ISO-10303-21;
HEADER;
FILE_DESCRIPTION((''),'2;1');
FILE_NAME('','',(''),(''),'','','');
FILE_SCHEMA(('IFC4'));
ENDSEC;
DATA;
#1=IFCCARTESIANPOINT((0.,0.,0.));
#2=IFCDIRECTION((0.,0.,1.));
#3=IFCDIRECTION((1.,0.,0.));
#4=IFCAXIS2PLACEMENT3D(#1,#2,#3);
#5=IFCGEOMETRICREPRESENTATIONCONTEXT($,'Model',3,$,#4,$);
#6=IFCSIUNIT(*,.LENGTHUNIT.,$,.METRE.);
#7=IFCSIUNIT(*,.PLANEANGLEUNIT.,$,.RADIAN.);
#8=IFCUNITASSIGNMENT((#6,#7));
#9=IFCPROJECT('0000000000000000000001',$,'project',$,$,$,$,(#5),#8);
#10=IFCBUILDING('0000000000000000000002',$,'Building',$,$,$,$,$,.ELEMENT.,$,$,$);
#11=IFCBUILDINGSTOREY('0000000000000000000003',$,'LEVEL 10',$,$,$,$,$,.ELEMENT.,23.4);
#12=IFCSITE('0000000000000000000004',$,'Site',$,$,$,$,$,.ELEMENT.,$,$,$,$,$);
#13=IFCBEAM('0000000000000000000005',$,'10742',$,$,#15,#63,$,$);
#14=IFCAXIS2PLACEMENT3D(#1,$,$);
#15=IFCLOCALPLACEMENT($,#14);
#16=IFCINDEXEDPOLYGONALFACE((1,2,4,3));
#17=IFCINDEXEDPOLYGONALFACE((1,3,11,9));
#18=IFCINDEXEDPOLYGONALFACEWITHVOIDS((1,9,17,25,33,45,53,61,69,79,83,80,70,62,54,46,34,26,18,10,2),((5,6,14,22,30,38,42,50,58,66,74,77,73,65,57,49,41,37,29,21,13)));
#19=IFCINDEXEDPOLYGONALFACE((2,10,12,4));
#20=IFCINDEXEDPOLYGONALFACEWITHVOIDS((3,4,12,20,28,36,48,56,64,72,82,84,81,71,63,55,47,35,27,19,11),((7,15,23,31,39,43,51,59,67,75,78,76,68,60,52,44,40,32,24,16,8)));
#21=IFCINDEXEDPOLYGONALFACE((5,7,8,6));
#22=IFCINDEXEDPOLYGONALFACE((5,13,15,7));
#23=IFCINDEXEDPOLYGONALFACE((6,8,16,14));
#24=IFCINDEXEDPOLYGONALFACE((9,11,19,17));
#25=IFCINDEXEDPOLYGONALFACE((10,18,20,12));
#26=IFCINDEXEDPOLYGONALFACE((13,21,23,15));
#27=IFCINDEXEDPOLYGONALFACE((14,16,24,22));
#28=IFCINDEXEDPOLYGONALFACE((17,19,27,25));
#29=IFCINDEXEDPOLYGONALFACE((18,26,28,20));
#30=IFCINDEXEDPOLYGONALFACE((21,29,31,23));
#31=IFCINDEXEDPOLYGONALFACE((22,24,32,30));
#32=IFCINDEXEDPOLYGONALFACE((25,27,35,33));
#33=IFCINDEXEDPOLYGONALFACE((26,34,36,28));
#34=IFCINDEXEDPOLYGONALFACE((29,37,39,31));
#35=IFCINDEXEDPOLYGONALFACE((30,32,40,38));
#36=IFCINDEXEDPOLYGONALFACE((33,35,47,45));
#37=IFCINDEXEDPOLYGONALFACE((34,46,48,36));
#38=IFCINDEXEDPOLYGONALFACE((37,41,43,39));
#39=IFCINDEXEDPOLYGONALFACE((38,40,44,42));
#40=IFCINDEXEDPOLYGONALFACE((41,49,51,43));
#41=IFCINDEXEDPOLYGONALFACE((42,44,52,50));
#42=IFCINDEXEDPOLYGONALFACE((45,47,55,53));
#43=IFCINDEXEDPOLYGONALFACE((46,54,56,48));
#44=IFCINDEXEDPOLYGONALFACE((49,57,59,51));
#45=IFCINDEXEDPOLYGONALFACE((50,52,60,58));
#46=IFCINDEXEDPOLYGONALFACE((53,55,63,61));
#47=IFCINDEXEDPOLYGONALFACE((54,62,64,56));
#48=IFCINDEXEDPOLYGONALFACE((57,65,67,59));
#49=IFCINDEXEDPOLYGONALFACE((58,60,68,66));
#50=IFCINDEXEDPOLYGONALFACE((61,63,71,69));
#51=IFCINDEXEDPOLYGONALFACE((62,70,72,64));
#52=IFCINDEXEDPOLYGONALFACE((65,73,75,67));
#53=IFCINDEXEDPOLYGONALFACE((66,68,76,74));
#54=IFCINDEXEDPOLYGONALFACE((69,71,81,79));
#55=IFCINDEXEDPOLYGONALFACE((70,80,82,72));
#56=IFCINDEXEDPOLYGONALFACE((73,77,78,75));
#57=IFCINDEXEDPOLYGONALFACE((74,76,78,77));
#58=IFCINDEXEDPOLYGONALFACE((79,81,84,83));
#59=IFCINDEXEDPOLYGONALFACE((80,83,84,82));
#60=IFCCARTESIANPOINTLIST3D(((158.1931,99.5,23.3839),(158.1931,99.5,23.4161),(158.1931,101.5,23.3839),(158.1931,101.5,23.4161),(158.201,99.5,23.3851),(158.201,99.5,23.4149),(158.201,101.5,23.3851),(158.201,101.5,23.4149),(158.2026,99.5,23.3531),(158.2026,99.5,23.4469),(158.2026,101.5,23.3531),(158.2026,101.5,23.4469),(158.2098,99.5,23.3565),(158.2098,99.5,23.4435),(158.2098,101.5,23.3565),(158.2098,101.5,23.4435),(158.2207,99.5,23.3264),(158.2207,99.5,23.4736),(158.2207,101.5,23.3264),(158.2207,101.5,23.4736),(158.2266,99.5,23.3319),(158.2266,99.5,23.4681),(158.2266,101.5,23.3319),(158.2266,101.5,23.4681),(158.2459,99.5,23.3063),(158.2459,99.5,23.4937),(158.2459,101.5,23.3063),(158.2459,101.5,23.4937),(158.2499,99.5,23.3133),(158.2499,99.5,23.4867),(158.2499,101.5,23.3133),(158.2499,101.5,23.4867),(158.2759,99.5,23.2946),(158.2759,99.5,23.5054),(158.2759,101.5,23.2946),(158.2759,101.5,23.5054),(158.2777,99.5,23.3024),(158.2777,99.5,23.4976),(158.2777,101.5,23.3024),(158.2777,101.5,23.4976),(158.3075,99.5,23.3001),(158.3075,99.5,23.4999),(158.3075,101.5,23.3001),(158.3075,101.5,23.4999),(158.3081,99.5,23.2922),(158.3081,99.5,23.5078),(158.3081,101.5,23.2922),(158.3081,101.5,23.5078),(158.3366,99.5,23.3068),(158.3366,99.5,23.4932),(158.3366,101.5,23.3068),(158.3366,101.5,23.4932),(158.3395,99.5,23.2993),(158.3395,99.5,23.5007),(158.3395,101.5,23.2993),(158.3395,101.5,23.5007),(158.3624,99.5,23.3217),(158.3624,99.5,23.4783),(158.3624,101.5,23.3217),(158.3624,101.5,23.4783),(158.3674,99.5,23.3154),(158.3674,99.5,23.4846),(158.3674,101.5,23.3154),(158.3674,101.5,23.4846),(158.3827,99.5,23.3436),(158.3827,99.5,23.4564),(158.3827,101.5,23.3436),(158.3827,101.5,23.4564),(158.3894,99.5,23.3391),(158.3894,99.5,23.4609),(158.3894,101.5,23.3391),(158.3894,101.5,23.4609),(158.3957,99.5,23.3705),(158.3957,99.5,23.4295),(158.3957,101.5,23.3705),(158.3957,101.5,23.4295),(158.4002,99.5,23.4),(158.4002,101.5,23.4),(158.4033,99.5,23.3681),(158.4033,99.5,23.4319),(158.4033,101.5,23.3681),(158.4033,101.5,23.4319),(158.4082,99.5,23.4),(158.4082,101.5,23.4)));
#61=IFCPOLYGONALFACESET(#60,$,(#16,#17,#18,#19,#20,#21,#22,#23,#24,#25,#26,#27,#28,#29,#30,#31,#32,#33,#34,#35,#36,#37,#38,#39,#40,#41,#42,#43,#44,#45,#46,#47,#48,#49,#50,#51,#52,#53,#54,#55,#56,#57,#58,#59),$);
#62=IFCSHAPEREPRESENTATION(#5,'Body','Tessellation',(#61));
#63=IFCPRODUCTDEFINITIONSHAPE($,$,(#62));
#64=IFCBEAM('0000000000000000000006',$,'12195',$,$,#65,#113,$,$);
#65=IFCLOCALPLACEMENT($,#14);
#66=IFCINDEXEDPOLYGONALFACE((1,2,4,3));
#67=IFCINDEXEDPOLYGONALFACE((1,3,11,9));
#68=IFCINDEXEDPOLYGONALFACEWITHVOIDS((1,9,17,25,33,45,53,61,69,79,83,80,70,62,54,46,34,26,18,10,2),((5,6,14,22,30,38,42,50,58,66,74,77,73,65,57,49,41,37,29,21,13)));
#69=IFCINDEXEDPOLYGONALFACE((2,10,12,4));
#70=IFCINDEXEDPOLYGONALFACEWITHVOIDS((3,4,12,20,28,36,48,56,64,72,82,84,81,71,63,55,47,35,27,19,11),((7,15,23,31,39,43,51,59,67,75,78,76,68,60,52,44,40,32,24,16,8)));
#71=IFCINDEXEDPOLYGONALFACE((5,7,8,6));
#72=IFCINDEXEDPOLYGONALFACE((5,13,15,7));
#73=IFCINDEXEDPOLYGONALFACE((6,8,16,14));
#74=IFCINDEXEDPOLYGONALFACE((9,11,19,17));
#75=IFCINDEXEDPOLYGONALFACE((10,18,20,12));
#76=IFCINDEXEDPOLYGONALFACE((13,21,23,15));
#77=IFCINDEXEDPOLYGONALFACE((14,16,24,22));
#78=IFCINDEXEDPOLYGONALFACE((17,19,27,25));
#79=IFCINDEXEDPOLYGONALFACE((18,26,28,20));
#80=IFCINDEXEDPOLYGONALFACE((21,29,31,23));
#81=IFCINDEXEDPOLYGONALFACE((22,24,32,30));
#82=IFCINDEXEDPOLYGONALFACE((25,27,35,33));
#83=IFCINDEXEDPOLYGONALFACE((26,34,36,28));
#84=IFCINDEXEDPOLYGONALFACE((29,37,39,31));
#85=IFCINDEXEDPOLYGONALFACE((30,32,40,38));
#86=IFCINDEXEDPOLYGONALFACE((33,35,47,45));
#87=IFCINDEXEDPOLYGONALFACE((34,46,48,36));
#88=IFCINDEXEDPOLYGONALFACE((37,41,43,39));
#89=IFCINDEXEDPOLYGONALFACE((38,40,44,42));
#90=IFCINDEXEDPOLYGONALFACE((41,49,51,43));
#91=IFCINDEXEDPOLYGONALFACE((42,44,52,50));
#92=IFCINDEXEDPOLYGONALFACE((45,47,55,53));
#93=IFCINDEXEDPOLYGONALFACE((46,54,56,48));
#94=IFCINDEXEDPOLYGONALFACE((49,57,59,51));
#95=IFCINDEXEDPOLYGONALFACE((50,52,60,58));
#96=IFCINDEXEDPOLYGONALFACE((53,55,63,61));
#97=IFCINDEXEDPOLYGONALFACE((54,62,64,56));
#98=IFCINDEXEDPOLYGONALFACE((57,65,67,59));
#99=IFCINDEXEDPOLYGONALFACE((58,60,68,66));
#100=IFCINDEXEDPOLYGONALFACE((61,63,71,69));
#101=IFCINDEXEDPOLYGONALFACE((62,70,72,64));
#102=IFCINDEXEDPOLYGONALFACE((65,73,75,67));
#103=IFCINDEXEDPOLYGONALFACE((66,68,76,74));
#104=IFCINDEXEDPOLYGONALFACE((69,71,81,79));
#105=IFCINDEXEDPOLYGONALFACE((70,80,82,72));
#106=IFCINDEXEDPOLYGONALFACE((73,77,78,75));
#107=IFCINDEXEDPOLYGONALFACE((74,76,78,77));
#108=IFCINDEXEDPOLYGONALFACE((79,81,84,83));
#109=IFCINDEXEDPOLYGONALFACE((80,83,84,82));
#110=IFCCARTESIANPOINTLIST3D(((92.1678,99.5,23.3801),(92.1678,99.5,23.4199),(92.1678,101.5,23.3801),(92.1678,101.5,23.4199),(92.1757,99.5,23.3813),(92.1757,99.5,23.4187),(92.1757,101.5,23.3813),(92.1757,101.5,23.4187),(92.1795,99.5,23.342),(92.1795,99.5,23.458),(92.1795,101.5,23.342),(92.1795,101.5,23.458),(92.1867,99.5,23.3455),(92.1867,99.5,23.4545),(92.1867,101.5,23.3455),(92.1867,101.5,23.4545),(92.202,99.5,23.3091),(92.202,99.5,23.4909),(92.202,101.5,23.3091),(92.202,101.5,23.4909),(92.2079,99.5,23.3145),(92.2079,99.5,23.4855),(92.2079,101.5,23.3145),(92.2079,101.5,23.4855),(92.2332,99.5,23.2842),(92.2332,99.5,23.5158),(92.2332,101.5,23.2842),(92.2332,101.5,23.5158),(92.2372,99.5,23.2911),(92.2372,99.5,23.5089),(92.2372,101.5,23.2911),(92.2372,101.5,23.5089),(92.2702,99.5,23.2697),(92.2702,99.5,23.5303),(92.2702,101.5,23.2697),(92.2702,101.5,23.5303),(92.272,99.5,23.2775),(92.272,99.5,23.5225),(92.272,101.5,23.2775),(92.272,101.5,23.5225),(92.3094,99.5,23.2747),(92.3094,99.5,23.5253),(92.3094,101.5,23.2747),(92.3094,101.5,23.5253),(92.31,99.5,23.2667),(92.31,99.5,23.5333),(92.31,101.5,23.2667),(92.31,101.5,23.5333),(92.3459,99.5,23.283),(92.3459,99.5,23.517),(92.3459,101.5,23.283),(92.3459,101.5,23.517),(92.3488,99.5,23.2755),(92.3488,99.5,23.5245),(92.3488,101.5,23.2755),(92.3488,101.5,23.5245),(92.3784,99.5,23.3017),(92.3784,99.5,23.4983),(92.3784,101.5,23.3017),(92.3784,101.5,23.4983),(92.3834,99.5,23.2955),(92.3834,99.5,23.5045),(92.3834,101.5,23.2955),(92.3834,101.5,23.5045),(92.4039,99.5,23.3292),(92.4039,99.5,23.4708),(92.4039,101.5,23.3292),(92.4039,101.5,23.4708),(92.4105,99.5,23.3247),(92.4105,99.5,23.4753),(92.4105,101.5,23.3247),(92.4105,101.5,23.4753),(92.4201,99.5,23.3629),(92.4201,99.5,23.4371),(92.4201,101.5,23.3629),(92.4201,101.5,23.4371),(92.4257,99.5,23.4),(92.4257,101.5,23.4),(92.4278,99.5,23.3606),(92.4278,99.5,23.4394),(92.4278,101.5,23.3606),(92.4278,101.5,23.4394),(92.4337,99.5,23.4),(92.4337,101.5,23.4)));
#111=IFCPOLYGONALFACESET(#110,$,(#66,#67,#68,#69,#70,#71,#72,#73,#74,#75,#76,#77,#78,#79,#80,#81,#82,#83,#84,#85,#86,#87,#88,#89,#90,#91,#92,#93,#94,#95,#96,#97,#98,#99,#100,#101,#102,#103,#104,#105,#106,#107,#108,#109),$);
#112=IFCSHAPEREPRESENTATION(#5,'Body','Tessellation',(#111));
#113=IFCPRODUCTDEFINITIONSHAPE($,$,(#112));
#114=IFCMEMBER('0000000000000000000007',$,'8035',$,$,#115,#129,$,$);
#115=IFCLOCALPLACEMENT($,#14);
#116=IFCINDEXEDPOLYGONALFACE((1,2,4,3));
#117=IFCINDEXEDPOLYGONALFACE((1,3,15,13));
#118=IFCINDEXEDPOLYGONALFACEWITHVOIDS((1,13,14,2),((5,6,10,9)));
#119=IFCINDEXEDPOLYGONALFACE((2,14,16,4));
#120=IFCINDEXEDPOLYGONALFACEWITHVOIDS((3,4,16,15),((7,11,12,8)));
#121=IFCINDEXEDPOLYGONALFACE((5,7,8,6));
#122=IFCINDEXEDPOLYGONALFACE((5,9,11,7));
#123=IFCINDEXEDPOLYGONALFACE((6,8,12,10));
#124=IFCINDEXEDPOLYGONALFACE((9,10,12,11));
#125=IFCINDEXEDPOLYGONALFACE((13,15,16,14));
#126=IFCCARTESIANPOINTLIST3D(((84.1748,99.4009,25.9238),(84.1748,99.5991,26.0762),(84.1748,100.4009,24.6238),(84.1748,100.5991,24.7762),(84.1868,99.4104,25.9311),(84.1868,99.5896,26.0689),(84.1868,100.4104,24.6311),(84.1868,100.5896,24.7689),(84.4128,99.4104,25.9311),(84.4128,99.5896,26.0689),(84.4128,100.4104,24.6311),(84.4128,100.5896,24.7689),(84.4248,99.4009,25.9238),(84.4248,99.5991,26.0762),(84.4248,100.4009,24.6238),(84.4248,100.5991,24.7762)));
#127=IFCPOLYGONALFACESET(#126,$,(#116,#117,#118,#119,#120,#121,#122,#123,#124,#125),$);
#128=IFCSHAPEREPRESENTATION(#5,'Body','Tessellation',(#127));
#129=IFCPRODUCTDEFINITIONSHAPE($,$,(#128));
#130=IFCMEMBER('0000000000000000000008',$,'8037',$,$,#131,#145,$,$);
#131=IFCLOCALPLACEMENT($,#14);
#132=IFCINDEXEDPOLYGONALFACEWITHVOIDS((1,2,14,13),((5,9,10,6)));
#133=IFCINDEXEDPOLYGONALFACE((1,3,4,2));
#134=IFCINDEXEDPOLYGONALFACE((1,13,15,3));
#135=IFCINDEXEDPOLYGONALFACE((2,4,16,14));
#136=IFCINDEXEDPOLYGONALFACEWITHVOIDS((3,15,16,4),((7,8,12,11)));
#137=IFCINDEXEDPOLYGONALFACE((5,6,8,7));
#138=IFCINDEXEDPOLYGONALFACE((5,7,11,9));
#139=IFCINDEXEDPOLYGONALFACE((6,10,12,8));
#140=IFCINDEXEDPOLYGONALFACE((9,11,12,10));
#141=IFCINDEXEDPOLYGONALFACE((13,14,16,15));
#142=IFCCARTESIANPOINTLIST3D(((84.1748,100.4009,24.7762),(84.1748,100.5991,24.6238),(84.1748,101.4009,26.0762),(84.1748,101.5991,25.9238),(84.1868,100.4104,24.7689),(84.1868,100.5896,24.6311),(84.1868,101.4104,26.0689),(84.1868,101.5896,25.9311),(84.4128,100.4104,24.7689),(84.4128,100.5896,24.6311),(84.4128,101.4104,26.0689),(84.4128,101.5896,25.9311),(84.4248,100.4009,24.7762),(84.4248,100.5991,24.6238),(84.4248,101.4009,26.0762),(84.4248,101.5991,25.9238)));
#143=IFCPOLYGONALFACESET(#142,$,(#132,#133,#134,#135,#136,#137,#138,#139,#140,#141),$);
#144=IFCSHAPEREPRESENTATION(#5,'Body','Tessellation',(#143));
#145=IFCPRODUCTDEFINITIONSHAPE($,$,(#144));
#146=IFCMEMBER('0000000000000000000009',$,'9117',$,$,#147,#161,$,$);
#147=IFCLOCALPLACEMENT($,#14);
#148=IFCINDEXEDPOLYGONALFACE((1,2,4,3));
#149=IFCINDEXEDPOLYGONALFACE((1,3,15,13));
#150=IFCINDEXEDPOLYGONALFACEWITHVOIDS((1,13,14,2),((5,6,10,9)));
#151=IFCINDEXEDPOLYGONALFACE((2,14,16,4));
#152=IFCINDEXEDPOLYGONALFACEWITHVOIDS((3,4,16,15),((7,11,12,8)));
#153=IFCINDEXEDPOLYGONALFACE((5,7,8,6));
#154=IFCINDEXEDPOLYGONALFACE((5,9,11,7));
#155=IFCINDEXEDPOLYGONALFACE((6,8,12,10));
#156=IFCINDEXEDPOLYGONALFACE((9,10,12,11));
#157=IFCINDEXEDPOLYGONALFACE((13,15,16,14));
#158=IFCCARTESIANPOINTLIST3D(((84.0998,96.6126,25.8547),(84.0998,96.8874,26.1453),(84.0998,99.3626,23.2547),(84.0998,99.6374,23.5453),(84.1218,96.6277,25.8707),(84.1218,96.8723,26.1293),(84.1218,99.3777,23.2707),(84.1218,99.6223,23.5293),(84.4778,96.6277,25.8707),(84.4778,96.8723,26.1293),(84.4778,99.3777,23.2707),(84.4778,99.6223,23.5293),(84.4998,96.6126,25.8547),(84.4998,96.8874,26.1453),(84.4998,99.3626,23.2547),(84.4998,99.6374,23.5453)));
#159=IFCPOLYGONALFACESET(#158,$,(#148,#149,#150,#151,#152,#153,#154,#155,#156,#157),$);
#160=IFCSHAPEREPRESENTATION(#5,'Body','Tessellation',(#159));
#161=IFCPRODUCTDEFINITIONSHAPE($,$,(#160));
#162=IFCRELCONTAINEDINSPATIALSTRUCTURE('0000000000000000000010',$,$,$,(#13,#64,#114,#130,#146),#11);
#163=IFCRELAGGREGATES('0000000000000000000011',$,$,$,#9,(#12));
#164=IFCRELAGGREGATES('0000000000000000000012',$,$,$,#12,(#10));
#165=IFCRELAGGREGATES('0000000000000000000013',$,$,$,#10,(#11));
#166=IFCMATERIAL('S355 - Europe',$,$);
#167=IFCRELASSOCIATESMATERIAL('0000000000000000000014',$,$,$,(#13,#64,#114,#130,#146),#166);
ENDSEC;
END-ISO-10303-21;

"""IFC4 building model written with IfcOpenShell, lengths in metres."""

from ifc_helpers import new_model, si_unit, frame, origin_with_axes, origin_2d_with_axis, place, context, project, spatial, hollow_rectangle, hollow_circle, extrude, material, material_profile, profile_set, profile_usage, element, save


model = new_model("IFC4")

# Units and contexts
model_context = context("Model", 3, world=origin_with_axes())
ifc_project = project(units=[si_unit("LENGTHUNIT", "METRE"), si_unit("PLANEANGLEUNIT", "RADIAN")], contexts=[model_context])

# Site, building, storey
site = spatial("IfcSite", under=ifc_project, Name="Site", CompositionType="ELEMENT")
building = spatial("IfcBuilding", under=site, Name="Building", CompositionType="ELEMENT")
storey = spatial("IfcBuildingStorey", under=building, Name="LEVEL 10", CompositionType="ELEMENT", Elevation=23.4)

# Shared definitions
ifc_material = material(Name="S355 - Europe")

# Beams
ifc_material_profile_1 = material_profile(ifc_material, hollow_circle(Radius=0.1081, WallThickness=0.008, at=origin_2d_with_axis()))
ifc_profile_set_1 = profile_set([ifc_material_profile_1])
ifc_profile_usage_1 = profile_usage(ifc_profile_set_1, cardinal=10)
beam_1_placement = place(None, frame((158.3, 101.5, 23.4), z_axis=(0.0, -1.0, 0.0), x_axis=(1.0, 0.0, 0.0)))
element("IfcBeam", 1, at=beam_1_placement, inside=storey, material=ifc_profile_usage_1, Name="10742", context=model_context, shape_type="SweptSolid", body=[
    extrude(hollow_circle(Radius=0.1081, WallThickness=0.008, at=origin_2d_with_axis()), origin_with_axes(), (0.0, 0.0, 1.0), 2.0),
])
ifc_material_profile_2 = material_profile(ifc_material, hollow_circle(Radius=0.1337, WallThickness=0.008, at=origin_2d_with_axis()))
ifc_profile_set_2 = profile_set([ifc_material_profile_2])
ifc_profile_usage_2 = profile_usage(ifc_profile_set_2, cardinal=10)
beam_2_placement = place(None, frame((92.3, 101.5, 23.4), z_axis=(0.0, -1.0, 0.0), x_axis=(1.0, 0.0, 0.0)))
element("IfcBeam", 2, at=beam_2_placement, inside=storey, material=ifc_profile_usage_2, Name="12195", context=model_context, shape_type="SweptSolid", body=[
    extrude(hollow_circle(Radius=0.1337, WallThickness=0.008, at=origin_2d_with_axis()), origin_with_axes(), (0.0, 0.0, 1.0), 2.0),
])

# Members
ifc_material_profile_3 = material_profile(ifc_material, hollow_rectangle(XDim=0.25, YDim=0.25, WallThickness=0.012, at=origin_2d_with_axis()))
ifc_profile_set_3 = profile_set([ifc_material_profile_3])
ifc_profile_usage_3 = profile_usage(ifc_profile_set_3, cardinal=10)
member_1_placement = place(None, frame((84.2998, 100.5, 24.7), z_axis=(0.0, -0.609711, 0.792624), x_axis=(1.0, 0.0, 0.0)))
element("IfcMember", 3, at=member_1_placement, inside=storey, material=ifc_profile_usage_3, Name="8035", context=model_context, shape_type="SweptSolid", body=[
    extrude(hollow_rectangle(XDim=0.25, YDim=0.25, WallThickness=0.012, at=origin_2d_with_axis()), origin_with_axes(), (0.0, 0.0, 1.0), 1.6401),
])
ifc_material_profile_4 = material_profile(ifc_material, hollow_rectangle(XDim=0.25, YDim=0.25, WallThickness=0.012, at=origin_2d_with_axis()))
ifc_profile_set_4 = profile_set([ifc_material_profile_4])
ifc_profile_usage_4 = profile_usage(ifc_profile_set_4, cardinal=10)
member_2_placement = place(None, frame((84.2998, 100.5, 24.7), z_axis=(0.0, 0.609711, 0.792624), x_axis=(-1.0, 0.0, 0.0)))
element("IfcMember", 4, at=member_2_placement, inside=storey, material=ifc_profile_usage_4, Name="8037", context=model_context, shape_type="SweptSolid", body=[
    extrude(hollow_rectangle(XDim=0.25, YDim=0.25, WallThickness=0.012, at=origin_2d_with_axis()), origin_with_axes(), (0.0, 0.0, 1.0), 1.6401),
])
ifc_material_profile_5 = material_profile(ifc_material, hollow_rectangle(XDim=0.4, YDim=0.4, WallThickness=0.022, at=origin_2d_with_axis()))
ifc_profile_set_5 = profile_set([ifc_material_profile_5])
ifc_profile_usage_5 = profile_usage(ifc_profile_set_5, cardinal=10)
member_3_placement = place(None, frame((84.2998, 99.5, 23.4), z_axis=(0.0, -0.726647, 0.687011), x_axis=(1.0, 0.0, 0.0)))
element("IfcMember", 5, at=member_3_placement, inside=storey, material=ifc_profile_usage_5, Name="9117", context=model_context, shape_type="SweptSolid", body=[
    extrude(hollow_rectangle(XDim=0.4, YDim=0.4, WallThickness=0.022, at=origin_2d_with_axis()), origin_with_axes(), (0.0, 0.0, 1.0), 3.7845),
])

save(model, "model.ifc")
